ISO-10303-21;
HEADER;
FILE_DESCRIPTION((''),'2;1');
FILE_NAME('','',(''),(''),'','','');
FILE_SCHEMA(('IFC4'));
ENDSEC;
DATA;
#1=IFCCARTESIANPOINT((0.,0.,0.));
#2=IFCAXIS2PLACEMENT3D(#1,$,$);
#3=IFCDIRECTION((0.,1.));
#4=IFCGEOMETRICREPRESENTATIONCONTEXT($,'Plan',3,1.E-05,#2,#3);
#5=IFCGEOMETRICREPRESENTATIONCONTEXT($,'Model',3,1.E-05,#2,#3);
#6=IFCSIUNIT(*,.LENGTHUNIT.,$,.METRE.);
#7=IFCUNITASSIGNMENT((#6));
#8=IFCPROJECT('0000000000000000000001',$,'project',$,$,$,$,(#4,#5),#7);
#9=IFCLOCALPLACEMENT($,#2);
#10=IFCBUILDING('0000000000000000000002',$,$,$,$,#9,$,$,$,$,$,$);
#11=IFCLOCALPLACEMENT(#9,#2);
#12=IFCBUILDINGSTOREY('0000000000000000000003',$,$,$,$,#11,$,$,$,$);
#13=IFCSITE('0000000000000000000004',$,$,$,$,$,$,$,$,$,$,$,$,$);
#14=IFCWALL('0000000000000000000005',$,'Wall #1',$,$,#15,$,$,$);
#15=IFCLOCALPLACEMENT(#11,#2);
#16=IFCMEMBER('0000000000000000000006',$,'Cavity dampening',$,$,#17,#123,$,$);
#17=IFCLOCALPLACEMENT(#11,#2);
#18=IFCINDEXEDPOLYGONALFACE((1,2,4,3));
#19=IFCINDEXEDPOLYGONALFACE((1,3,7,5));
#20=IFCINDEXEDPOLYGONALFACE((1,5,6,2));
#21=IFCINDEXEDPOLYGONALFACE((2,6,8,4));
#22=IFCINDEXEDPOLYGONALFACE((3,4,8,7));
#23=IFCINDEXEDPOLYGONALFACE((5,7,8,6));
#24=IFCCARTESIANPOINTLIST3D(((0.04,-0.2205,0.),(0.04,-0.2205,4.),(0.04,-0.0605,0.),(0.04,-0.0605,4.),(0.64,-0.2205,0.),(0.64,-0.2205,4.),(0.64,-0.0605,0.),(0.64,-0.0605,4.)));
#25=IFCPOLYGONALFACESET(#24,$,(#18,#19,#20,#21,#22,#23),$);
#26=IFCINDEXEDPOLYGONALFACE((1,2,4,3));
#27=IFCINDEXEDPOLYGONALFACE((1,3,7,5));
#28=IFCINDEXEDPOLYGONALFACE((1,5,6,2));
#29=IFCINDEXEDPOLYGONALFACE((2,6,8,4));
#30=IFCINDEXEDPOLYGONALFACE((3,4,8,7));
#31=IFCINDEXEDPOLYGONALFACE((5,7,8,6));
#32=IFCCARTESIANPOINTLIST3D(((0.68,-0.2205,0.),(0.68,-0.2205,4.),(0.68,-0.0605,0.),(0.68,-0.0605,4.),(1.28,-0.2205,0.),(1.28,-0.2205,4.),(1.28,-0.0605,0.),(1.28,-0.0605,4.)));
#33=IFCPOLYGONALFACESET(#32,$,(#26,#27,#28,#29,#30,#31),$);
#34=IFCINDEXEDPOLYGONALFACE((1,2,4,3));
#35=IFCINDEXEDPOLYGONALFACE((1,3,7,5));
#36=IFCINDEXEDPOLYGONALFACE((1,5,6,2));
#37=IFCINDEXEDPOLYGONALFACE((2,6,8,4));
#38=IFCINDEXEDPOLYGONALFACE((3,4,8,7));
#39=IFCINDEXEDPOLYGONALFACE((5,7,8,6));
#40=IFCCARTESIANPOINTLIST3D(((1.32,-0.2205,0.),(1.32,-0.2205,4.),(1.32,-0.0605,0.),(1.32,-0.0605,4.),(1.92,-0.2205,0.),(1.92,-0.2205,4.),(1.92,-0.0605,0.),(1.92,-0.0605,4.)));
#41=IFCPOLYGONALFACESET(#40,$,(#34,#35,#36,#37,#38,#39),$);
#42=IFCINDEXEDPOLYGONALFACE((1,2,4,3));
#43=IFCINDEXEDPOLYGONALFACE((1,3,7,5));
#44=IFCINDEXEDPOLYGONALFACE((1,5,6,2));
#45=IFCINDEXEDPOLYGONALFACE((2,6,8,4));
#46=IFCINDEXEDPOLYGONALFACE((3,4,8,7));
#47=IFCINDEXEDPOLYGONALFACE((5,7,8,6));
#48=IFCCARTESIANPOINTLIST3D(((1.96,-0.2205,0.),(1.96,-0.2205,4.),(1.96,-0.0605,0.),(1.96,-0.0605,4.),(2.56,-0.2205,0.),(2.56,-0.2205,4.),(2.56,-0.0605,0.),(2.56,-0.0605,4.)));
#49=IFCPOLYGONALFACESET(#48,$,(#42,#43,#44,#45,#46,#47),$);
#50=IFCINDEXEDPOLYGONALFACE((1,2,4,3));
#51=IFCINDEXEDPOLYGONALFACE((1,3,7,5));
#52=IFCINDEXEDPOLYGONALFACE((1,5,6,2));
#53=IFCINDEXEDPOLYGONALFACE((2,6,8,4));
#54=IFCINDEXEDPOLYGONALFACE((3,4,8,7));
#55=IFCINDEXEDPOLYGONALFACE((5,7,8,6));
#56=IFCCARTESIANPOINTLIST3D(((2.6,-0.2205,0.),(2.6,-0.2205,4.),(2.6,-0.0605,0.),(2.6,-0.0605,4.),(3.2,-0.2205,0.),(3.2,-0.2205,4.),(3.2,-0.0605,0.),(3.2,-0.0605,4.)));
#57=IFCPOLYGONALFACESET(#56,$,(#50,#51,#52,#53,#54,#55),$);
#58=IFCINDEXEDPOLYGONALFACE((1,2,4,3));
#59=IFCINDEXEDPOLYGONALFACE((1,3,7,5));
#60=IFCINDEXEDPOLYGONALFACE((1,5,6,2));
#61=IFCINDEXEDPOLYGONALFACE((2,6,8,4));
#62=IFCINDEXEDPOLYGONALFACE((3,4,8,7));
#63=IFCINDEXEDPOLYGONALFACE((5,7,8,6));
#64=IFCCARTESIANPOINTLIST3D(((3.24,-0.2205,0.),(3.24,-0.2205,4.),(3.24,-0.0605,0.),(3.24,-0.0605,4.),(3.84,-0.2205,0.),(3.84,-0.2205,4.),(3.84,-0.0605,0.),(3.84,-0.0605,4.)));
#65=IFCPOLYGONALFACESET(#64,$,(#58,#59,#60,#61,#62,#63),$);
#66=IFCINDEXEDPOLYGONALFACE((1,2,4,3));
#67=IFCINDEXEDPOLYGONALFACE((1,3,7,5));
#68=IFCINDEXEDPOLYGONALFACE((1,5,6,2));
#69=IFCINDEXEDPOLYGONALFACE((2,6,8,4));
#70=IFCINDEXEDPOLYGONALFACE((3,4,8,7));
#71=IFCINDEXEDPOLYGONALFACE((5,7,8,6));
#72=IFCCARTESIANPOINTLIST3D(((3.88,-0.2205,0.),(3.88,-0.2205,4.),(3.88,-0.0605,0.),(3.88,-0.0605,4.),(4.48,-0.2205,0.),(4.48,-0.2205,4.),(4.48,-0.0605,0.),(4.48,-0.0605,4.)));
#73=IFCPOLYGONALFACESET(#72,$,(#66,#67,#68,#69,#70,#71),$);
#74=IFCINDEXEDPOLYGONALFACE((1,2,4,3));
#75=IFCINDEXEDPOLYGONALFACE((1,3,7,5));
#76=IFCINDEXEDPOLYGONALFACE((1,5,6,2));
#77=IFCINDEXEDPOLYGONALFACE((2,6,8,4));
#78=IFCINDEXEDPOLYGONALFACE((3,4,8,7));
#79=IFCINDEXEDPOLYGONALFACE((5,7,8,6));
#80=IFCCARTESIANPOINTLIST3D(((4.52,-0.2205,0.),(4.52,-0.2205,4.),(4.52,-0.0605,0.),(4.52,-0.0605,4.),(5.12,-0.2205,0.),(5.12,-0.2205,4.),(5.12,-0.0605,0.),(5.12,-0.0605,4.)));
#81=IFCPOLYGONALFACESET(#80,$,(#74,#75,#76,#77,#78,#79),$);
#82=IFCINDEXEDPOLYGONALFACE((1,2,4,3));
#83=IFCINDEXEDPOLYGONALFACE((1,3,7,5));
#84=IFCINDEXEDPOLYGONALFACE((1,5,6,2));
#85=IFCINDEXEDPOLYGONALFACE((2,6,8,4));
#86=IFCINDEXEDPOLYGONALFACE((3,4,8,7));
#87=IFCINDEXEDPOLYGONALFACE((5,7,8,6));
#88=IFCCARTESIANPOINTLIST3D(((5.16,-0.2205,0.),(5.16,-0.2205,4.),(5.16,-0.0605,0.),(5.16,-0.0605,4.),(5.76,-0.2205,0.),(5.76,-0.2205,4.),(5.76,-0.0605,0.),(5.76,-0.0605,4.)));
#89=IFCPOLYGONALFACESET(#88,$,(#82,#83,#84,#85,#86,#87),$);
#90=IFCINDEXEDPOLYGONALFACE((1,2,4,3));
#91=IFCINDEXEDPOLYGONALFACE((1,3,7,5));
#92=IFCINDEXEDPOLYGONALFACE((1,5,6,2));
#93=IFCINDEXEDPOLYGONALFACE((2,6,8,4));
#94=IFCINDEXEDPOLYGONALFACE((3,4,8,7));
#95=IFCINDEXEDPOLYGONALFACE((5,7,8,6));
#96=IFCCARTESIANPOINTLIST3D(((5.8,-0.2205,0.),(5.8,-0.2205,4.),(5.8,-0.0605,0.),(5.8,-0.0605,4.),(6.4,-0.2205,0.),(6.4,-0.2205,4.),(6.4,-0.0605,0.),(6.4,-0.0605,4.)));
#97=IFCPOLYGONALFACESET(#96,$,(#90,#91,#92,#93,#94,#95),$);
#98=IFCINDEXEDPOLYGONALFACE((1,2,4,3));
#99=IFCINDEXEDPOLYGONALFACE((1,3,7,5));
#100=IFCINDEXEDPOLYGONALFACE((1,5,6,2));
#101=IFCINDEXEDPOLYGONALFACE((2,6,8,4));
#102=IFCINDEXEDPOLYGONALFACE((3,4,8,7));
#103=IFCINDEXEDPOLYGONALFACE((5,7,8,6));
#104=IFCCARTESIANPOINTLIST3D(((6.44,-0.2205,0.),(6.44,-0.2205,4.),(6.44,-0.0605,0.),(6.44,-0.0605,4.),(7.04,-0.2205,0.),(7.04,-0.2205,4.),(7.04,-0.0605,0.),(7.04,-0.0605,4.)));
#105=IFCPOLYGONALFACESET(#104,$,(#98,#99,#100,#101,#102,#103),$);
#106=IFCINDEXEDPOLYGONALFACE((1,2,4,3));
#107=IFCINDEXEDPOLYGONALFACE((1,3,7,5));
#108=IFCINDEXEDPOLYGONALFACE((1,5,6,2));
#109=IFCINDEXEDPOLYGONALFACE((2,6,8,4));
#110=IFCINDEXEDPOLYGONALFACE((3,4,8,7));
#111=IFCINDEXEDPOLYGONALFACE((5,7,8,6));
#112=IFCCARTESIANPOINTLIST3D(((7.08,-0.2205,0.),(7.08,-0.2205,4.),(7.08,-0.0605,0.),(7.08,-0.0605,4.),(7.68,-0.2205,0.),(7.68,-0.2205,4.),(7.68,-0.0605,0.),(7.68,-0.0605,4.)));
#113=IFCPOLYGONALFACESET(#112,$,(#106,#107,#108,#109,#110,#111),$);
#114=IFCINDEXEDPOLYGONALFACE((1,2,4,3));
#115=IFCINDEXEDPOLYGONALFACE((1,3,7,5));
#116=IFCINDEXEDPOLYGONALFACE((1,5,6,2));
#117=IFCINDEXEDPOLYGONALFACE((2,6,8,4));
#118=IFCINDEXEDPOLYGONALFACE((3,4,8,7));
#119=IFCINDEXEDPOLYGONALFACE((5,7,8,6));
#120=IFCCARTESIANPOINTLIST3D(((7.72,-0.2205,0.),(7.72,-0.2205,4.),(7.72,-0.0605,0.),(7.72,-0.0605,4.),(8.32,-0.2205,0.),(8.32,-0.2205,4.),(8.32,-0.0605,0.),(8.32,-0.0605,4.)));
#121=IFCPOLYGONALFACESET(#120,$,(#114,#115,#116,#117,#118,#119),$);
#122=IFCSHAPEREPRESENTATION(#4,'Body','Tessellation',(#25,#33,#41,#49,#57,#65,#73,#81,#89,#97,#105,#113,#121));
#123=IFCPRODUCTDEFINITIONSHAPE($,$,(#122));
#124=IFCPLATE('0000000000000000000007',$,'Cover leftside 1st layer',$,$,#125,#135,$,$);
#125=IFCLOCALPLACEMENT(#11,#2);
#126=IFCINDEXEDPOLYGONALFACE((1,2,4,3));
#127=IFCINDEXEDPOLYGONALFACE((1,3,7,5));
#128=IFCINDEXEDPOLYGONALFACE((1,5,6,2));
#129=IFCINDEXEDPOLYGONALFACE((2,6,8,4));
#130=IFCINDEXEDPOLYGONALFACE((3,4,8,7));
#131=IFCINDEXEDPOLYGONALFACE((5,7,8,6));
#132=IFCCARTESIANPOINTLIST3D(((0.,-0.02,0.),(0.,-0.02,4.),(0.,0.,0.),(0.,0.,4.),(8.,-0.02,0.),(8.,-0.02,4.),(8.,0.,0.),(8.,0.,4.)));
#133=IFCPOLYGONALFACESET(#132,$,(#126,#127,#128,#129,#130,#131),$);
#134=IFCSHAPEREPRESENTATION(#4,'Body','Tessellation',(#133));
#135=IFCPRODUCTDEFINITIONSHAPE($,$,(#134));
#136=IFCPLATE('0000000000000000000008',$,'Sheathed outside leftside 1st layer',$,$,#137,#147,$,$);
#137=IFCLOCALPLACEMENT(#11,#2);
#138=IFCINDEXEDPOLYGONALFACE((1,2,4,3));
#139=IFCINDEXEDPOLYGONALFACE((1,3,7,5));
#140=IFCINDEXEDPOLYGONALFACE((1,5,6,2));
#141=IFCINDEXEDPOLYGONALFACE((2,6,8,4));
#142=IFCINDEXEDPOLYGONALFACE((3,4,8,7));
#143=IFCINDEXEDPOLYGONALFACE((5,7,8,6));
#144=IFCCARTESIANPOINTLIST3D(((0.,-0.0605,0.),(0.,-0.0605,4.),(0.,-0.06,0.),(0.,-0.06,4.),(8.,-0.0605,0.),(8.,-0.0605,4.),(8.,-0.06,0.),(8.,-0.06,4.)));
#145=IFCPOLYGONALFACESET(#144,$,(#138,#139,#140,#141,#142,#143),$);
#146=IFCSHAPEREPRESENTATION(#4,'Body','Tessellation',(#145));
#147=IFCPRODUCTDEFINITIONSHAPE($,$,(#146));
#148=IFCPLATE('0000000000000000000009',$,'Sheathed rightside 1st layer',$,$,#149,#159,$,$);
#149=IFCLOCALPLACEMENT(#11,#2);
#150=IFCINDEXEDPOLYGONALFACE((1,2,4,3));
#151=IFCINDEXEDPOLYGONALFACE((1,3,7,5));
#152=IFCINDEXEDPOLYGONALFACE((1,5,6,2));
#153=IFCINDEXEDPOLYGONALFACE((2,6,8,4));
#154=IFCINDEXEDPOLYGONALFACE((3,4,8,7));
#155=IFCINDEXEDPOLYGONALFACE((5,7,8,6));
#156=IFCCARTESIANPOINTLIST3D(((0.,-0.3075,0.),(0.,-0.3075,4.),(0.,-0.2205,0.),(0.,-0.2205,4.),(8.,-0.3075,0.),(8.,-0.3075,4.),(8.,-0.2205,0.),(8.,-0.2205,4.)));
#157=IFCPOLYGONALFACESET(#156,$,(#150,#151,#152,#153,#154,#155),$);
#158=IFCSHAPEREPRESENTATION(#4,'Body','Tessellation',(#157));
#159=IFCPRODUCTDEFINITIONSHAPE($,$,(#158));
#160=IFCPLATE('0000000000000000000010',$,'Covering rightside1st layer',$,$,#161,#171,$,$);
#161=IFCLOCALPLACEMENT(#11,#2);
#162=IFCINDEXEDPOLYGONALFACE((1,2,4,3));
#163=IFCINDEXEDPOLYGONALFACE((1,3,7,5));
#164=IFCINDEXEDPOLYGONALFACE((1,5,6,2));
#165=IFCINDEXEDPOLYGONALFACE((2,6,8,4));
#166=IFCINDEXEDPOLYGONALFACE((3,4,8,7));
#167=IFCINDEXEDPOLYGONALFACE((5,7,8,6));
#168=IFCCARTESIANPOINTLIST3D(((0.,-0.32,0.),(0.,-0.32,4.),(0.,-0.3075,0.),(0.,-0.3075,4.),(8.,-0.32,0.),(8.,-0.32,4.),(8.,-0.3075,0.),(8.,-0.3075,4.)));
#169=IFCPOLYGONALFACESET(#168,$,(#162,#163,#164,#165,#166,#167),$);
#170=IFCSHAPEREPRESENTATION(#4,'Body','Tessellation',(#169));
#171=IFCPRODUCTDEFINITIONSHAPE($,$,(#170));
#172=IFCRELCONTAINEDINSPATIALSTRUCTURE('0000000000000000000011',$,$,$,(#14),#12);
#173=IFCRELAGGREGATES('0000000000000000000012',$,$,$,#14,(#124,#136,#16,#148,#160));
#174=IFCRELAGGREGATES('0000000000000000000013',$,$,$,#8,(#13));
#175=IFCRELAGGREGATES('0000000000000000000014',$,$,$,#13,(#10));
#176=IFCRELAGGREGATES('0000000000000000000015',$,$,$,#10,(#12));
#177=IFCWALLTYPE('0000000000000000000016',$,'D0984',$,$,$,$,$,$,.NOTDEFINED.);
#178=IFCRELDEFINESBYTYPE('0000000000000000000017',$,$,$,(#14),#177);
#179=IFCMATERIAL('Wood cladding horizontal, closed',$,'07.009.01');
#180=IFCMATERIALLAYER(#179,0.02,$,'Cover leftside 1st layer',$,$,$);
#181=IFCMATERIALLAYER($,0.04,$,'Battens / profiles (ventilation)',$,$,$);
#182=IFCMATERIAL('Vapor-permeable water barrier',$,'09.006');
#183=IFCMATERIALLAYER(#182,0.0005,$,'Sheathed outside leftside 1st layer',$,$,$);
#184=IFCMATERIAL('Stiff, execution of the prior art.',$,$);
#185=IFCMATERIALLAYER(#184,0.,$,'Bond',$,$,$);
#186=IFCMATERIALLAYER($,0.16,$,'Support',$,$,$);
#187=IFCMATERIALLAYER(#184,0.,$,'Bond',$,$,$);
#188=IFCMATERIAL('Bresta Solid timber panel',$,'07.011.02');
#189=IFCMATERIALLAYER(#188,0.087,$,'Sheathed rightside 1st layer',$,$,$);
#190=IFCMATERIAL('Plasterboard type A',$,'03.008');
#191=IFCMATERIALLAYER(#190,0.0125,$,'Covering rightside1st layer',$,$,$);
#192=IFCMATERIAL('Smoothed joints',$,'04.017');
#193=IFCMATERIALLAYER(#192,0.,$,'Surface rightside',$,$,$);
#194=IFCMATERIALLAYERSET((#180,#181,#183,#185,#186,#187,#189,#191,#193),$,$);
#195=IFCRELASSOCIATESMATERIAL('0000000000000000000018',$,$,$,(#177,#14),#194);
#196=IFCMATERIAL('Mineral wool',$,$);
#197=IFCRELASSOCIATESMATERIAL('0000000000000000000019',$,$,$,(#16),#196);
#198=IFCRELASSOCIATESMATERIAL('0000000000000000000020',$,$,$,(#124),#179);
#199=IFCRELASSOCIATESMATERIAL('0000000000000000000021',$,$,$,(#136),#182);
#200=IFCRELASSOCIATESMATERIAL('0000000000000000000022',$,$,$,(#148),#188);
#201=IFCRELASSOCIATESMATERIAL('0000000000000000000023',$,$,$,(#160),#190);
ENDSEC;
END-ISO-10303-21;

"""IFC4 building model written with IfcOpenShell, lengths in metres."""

from ifc_helpers import new_model, si_unit, direction, frame, frame_2d, origin, origin_with_axes, place, context, project, spatial, rectangle, extrude, material, layer, layer_set, type_object, element, aggregate, save


model = new_model("IFC4")

# Units and contexts
plan_context = context("Plan", 3, precision=1e-05, world=origin(), true_north=direction((0.0, 1.0)))
model_context = context("Model", 3, precision=1e-05, world=origin(), true_north=direction((0.0, 1.0)))
ifc_project = project(units=[si_unit("LENGTHUNIT", "METRE")], contexts=[plan_context, model_context])

# Site, building, storey
site = spatial("IfcSite", under=ifc_project)
building_placement = place(None, origin())
building = spatial("IfcBuilding", under=site, at=building_placement)
storey_placement = place(building_placement, origin())
storey = spatial("IfcBuildingStorey", under=building, at=storey_placement)

# Wall, member, plates
ifc_material_1 = material(Name="Wood cladding horizontal, closed", Category="07.009.01")
ifc_layer_1 = layer(ifc_material_1, 0.02, Name="Cover leftside 1st layer")
ifc_layer_2 = layer(None, 0.04, Name="Battens / profiles (ventilation)")
ifc_material_2 = material(Name="Vapor-permeable water barrier", Category="09.006")
ifc_layer_3 = layer(ifc_material_2, 0.0005, Name="Sheathed outside leftside 1st layer")
ifc_material_3 = material(Name="Stiff, execution of the prior art.")
ifc_layer_4 = layer(ifc_material_3, 0.0, Name="Bond")
ifc_layer_5 = layer(None, 0.16, Name="Support")
ifc_layer_6 = layer(ifc_material_3, 0.0, Name="Bond")
ifc_material_4 = material(Name="Bresta Solid timber panel", Category="07.011.02")
ifc_layer_7 = layer(ifc_material_4, 0.087, Name="Sheathed rightside 1st layer")
ifc_material_5 = material(Name="Plasterboard type A", Category="03.008")
ifc_layer_8 = layer(ifc_material_5, 0.0125, Name="Covering rightside1st layer")
ifc_material_6 = material(Name="Smoothed joints", Category="04.017")
ifc_layer_9 = layer(ifc_material_6, 0.0, Name="Surface rightside")
ifc_layer_set = layer_set([ifc_layer_1, ifc_layer_2, ifc_layer_3, ifc_layer_4, ifc_layer_5, ifc_layer_6, ifc_layer_7, ifc_layer_8, ifc_layer_9])
wall_type = type_object("IfcWallType", Name="D0984", PredefinedType="NOTDEFINED", material=ifc_layer_set)
wall_placement = place(None, frame((0.0, 0.0, 0.0), z_axis=(0.0, -1.0, 0.0), x_axis=(1.0, 0.0, 0.0)))
wall = element("IfcWall", 1, at=wall_placement, inside=storey, type_object=wall_type, material=ifc_layer_set, Name="Wall #1")
ifc_material_7 = material(Name="Mineral wool")
member_1_placement = place(wall_placement, origin())
member_1 = element("IfcMember", 2, at=member_1_placement, material=ifc_material_7, Name="Cavity dampening", context=plan_context, shape_type="SweptSolid", body=[
    extrude(rectangle(XDim=0.6, YDim=0.16, at=frame_2d((0.3, 0.08), x_axis=(1.0, 0.0))), frame((0.04, 4.0, 0.0605), z_axis=(0.0, -1.0, 0.0), x_axis=(1.0, 0.0, 0.0)), (0.0, 0.0, 1.0), 4.0),
    extrude(rectangle(XDim=0.6, YDim=0.16, at=frame_2d((0.3, 0.08), x_axis=(1.0, 0.0))), frame((0.68, 4.0, 0.0605), z_axis=(0.0, -1.0, 0.0), x_axis=(1.0, 0.0, 0.0)), (0.0, 0.0, 1.0), 4.0),
    extrude(rectangle(XDim=0.6, YDim=0.16, at=frame_2d((0.3, 0.08), x_axis=(1.0, 0.0))), frame((1.32, 4.0, 0.0605), z_axis=(0.0, -1.0, 0.0), x_axis=(1.0, 0.0, 0.0)), (0.0, 0.0, 1.0), 4.0),
    extrude(rectangle(XDim=0.6, YDim=0.16, at=frame_2d((0.3, 0.08), x_axis=(1.0, 0.0))), frame((1.96, 4.0, 0.0605), z_axis=(0.0, -1.0, 0.0), x_axis=(1.0, 0.0, 0.0)), (0.0, 0.0, 1.0), 4.0),
    extrude(rectangle(XDim=0.6, YDim=0.16, at=frame_2d((0.3, 0.08), x_axis=(1.0, 0.0))), frame((2.6, 4.0, 0.0605), z_axis=(0.0, -1.0, 0.0), x_axis=(1.0, 0.0, 0.0)), (0.0, 0.0, 1.0), 4.0),
    extrude(rectangle(XDim=0.6, YDim=0.16, at=frame_2d((0.3, 0.08), x_axis=(1.0, 0.0))), frame((3.24, 4.0, 0.0605), z_axis=(0.0, -1.0, 0.0), x_axis=(1.0, 0.0, 0.0)), (0.0, 0.0, 1.0), 4.0),
    extrude(rectangle(XDim=0.6, YDim=0.16, at=frame_2d((0.3, 0.08), x_axis=(1.0, 0.0))), frame((3.88, 4.0, 0.0605), z_axis=(0.0, -1.0, 0.0), x_axis=(1.0, 0.0, 0.0)), (0.0, 0.0, 1.0), 4.0),
    extrude(rectangle(XDim=0.6, YDim=0.16, at=frame_2d((0.3, 0.08), x_axis=(1.0, 0.0))), frame((4.52, 4.0, 0.0605), z_axis=(0.0, -1.0, 0.0), x_axis=(1.0, 0.0, 0.0)), (0.0, 0.0, 1.0), 4.0),
    extrude(rectangle(XDim=0.6, YDim=0.16, at=frame_2d((0.3, 0.08), x_axis=(1.0, 0.0))), frame((5.16, 4.0, 0.0605), z_axis=(0.0, -1.0, 0.0), x_axis=(1.0, 0.0, 0.0)), (0.0, 0.0, 1.0), 4.0),
    extrude(rectangle(XDim=0.6, YDim=0.16, at=frame_2d((0.3, 0.08), x_axis=(1.0, 0.0))), frame((5.8, 4.0, 0.0605), z_axis=(0.0, -1.0, 0.0), x_axis=(1.0, 0.0, 0.0)), (0.0, 0.0, 1.0), 4.0),
    extrude(rectangle(XDim=0.6, YDim=0.16, at=frame_2d((0.3, 0.08), x_axis=(1.0, 0.0))), frame((6.44, 4.0, 0.0605), z_axis=(0.0, -1.0, 0.0), x_axis=(1.0, 0.0, 0.0)), (0.0, 0.0, 1.0), 4.0),
    extrude(rectangle(XDim=0.6, YDim=0.16, at=frame_2d((0.3, 0.08), x_axis=(1.0, 0.0))), frame((7.08, 4.0, 0.0605), z_axis=(0.0, -1.0, 0.0), x_axis=(1.0, 0.0, 0.0)), (0.0, 0.0, 1.0), 4.0),
    extrude(rectangle(XDim=0.6, YDim=0.16, at=frame_2d((0.3, 0.08), x_axis=(1.0, 0.0))), frame((7.72, 4.0, 0.0605), z_axis=(0.0, -1.0, 0.0), x_axis=(1.0, 0.0, 0.0)), (0.0, 0.0, 1.0), 4.0),
])
plate_1_placement = place(wall_placement, origin())
plate_1 = element("IfcPlate", 3, at=plate_1_placement, material=ifc_material_1, Name="Cover leftside 1st layer", context=plan_context, shape_type="SweptSolid", body=[
    extrude(rectangle(XDim=8.0, YDim=4.0, at=frame_2d((4.0, 2.0), x_axis=(1.0, 0.0))), origin_with_axes(), (0.0, 0.0, 1.0), 0.02),
])
plate_2_placement = place(wall_placement, origin())
plate_2 = element("IfcPlate", 4, at=plate_2_placement, material=ifc_material_2, Name="Sheathed outside leftside 1st layer", context=plan_context, shape_type="SweptSolid", body=[
    extrude(rectangle(XDim=8.0, YDim=4.0, at=frame_2d((4.0, 2.0), x_axis=(1.0, 0.0))), frame((0.0, 0.0, 0.06), z_axis=(0.0, 0.0, 1.0), x_axis=(1.0, 0.0, 0.0)), (0.0, 0.0, 1.0), 0.0005),
])
plate_3_placement = place(wall_placement, origin())
plate_3 = element("IfcPlate", 5, at=plate_3_placement, material=ifc_material_4, Name="Sheathed rightside 1st layer", context=plan_context, shape_type="SweptSolid", body=[
    extrude(rectangle(XDim=8.0, YDim=4.0, at=frame_2d((4.0, 2.0), x_axis=(1.0, 0.0))), frame((0.0, 0.0, 0.2205), z_axis=(0.0, 0.0, 1.0), x_axis=(1.0, 0.0, 0.0)), (0.0, 0.0, 1.0), 0.087),
])
plate_4_placement = place(wall_placement, origin())
plate_4 = element("IfcPlate", 6, at=plate_4_placement, material=ifc_material_5, Name="Covering rightside1st layer", context=plan_context, shape_type="SweptSolid", body=[
    extrude(rectangle(XDim=8.0, YDim=4.0, at=frame_2d((4.0, 2.0), x_axis=(1.0, 0.0))), frame((0.0, 0.0, 0.3075), z_axis=(0.0, 0.0, 1.0), x_axis=(1.0, 0.0, 0.0)), (0.0, 0.0, 1.0), 0.0125),
])
aggregate(wall, [plate_1, plate_2, member_1, plate_3, plate_4])

save(model, "model.ifc")
